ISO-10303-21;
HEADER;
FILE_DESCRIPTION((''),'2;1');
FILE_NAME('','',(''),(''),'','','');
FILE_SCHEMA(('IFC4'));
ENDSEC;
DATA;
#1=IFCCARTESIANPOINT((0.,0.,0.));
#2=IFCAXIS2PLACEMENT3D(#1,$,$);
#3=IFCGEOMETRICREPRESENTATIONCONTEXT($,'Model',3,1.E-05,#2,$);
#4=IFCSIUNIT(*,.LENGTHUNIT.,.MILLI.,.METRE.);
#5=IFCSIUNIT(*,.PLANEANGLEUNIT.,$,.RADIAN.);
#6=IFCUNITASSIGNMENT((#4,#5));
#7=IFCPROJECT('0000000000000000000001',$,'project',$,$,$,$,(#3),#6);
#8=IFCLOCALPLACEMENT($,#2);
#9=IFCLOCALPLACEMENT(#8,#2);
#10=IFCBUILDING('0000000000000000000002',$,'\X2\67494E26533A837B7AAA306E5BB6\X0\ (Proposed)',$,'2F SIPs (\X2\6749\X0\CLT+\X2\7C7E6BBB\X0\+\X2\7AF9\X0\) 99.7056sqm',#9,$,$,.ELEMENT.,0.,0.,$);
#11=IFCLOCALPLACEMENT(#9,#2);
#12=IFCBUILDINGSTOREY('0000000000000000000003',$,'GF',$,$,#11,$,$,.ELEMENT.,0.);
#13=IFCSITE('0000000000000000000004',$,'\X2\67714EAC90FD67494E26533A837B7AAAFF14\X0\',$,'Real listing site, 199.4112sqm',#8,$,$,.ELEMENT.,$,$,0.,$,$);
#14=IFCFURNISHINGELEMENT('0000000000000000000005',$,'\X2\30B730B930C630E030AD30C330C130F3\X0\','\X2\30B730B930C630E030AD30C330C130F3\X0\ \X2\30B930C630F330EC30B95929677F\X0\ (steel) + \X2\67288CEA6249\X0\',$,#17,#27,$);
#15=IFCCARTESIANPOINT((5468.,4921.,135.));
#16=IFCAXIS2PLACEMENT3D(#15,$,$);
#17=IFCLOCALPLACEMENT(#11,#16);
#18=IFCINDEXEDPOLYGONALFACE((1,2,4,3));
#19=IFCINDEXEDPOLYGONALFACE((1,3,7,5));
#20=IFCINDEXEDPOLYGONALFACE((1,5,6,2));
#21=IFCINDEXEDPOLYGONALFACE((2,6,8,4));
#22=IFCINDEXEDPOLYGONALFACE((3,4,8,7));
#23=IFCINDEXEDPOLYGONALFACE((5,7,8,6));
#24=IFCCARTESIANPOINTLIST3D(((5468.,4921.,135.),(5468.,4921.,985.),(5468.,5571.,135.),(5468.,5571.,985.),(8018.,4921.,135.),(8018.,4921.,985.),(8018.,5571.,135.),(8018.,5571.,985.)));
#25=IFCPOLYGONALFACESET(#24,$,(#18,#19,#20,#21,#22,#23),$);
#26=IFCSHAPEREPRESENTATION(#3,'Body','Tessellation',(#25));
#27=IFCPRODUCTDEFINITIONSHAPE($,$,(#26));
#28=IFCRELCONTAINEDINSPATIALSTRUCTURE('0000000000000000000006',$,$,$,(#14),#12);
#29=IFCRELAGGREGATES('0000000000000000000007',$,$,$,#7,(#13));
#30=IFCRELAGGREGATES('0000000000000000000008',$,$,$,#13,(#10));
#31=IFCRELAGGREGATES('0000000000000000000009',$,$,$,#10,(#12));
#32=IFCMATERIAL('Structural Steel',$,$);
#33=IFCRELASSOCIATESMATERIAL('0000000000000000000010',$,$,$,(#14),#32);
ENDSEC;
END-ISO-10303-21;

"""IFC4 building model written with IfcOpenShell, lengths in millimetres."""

from ifc_helpers import new_model, si_unit, frame, frame_2d, origin, place, context, project, spatial, rectangle, extrude, material, element, save


model = new_model("IFC4")

# Units and contexts
model_context = context("Model", 3, precision=1e-05, world=origin())
ifc_project = project(units=[si_unit("LENGTHUNIT", "METRE", prefix="MILLI"), si_unit("PLANEANGLEUNIT", "RADIAN")], contexts=[model_context])

# Site, building, storey
site_placement = place(None, origin())
site = spatial("IfcSite", under=ifc_project, at=site_placement, Name="東京都杉並区荻窪４", ObjectType="Real listing site, 199.4112sqm", CompositionType="ELEMENT", RefElevation=0.0)
building_placement = place(site_placement, origin())
building = spatial("IfcBuilding", under=site, at=building_placement, Name="杉並区荻窪の家 (Proposed)", ObjectType="2F SIPs (杉CLT+籾殻+竹) 99.7056sqm", CompositionType="ELEMENT", ElevationOfRefHeight=0.0, ElevationOfTerrain=0.0)
storey_placement = place(building_placement, origin())
storey = spatial("IfcBuildingStorey", under=building, at=storey_placement, Name="GF", CompositionType="ELEMENT", Elevation=0.0)

# Furnishing element
ifc_material_1 = material(Name="Structural Steel")
furnishing_1_placement = place(storey_placement, frame((5468.0, 4921.0, 135.0)))
element("IfcFurnishingElement", 1, at=furnishing_1_placement, inside=storey, material=ifc_material_1, Name="システムキッチン", Description="システムキッチン ステンレス天板 (steel) + 木質扉", context=model_context, shape_type="SweptSolid", body=[
    extrude(rectangle(XDim=2550.0, YDim=650.0, at=frame_2d((1275.0, 325.0))), frame((5468.0, 4921.0, 135.0)), (0.0, 0.0, 1.0), 850.0),
])

save(model, "model.ifc")
